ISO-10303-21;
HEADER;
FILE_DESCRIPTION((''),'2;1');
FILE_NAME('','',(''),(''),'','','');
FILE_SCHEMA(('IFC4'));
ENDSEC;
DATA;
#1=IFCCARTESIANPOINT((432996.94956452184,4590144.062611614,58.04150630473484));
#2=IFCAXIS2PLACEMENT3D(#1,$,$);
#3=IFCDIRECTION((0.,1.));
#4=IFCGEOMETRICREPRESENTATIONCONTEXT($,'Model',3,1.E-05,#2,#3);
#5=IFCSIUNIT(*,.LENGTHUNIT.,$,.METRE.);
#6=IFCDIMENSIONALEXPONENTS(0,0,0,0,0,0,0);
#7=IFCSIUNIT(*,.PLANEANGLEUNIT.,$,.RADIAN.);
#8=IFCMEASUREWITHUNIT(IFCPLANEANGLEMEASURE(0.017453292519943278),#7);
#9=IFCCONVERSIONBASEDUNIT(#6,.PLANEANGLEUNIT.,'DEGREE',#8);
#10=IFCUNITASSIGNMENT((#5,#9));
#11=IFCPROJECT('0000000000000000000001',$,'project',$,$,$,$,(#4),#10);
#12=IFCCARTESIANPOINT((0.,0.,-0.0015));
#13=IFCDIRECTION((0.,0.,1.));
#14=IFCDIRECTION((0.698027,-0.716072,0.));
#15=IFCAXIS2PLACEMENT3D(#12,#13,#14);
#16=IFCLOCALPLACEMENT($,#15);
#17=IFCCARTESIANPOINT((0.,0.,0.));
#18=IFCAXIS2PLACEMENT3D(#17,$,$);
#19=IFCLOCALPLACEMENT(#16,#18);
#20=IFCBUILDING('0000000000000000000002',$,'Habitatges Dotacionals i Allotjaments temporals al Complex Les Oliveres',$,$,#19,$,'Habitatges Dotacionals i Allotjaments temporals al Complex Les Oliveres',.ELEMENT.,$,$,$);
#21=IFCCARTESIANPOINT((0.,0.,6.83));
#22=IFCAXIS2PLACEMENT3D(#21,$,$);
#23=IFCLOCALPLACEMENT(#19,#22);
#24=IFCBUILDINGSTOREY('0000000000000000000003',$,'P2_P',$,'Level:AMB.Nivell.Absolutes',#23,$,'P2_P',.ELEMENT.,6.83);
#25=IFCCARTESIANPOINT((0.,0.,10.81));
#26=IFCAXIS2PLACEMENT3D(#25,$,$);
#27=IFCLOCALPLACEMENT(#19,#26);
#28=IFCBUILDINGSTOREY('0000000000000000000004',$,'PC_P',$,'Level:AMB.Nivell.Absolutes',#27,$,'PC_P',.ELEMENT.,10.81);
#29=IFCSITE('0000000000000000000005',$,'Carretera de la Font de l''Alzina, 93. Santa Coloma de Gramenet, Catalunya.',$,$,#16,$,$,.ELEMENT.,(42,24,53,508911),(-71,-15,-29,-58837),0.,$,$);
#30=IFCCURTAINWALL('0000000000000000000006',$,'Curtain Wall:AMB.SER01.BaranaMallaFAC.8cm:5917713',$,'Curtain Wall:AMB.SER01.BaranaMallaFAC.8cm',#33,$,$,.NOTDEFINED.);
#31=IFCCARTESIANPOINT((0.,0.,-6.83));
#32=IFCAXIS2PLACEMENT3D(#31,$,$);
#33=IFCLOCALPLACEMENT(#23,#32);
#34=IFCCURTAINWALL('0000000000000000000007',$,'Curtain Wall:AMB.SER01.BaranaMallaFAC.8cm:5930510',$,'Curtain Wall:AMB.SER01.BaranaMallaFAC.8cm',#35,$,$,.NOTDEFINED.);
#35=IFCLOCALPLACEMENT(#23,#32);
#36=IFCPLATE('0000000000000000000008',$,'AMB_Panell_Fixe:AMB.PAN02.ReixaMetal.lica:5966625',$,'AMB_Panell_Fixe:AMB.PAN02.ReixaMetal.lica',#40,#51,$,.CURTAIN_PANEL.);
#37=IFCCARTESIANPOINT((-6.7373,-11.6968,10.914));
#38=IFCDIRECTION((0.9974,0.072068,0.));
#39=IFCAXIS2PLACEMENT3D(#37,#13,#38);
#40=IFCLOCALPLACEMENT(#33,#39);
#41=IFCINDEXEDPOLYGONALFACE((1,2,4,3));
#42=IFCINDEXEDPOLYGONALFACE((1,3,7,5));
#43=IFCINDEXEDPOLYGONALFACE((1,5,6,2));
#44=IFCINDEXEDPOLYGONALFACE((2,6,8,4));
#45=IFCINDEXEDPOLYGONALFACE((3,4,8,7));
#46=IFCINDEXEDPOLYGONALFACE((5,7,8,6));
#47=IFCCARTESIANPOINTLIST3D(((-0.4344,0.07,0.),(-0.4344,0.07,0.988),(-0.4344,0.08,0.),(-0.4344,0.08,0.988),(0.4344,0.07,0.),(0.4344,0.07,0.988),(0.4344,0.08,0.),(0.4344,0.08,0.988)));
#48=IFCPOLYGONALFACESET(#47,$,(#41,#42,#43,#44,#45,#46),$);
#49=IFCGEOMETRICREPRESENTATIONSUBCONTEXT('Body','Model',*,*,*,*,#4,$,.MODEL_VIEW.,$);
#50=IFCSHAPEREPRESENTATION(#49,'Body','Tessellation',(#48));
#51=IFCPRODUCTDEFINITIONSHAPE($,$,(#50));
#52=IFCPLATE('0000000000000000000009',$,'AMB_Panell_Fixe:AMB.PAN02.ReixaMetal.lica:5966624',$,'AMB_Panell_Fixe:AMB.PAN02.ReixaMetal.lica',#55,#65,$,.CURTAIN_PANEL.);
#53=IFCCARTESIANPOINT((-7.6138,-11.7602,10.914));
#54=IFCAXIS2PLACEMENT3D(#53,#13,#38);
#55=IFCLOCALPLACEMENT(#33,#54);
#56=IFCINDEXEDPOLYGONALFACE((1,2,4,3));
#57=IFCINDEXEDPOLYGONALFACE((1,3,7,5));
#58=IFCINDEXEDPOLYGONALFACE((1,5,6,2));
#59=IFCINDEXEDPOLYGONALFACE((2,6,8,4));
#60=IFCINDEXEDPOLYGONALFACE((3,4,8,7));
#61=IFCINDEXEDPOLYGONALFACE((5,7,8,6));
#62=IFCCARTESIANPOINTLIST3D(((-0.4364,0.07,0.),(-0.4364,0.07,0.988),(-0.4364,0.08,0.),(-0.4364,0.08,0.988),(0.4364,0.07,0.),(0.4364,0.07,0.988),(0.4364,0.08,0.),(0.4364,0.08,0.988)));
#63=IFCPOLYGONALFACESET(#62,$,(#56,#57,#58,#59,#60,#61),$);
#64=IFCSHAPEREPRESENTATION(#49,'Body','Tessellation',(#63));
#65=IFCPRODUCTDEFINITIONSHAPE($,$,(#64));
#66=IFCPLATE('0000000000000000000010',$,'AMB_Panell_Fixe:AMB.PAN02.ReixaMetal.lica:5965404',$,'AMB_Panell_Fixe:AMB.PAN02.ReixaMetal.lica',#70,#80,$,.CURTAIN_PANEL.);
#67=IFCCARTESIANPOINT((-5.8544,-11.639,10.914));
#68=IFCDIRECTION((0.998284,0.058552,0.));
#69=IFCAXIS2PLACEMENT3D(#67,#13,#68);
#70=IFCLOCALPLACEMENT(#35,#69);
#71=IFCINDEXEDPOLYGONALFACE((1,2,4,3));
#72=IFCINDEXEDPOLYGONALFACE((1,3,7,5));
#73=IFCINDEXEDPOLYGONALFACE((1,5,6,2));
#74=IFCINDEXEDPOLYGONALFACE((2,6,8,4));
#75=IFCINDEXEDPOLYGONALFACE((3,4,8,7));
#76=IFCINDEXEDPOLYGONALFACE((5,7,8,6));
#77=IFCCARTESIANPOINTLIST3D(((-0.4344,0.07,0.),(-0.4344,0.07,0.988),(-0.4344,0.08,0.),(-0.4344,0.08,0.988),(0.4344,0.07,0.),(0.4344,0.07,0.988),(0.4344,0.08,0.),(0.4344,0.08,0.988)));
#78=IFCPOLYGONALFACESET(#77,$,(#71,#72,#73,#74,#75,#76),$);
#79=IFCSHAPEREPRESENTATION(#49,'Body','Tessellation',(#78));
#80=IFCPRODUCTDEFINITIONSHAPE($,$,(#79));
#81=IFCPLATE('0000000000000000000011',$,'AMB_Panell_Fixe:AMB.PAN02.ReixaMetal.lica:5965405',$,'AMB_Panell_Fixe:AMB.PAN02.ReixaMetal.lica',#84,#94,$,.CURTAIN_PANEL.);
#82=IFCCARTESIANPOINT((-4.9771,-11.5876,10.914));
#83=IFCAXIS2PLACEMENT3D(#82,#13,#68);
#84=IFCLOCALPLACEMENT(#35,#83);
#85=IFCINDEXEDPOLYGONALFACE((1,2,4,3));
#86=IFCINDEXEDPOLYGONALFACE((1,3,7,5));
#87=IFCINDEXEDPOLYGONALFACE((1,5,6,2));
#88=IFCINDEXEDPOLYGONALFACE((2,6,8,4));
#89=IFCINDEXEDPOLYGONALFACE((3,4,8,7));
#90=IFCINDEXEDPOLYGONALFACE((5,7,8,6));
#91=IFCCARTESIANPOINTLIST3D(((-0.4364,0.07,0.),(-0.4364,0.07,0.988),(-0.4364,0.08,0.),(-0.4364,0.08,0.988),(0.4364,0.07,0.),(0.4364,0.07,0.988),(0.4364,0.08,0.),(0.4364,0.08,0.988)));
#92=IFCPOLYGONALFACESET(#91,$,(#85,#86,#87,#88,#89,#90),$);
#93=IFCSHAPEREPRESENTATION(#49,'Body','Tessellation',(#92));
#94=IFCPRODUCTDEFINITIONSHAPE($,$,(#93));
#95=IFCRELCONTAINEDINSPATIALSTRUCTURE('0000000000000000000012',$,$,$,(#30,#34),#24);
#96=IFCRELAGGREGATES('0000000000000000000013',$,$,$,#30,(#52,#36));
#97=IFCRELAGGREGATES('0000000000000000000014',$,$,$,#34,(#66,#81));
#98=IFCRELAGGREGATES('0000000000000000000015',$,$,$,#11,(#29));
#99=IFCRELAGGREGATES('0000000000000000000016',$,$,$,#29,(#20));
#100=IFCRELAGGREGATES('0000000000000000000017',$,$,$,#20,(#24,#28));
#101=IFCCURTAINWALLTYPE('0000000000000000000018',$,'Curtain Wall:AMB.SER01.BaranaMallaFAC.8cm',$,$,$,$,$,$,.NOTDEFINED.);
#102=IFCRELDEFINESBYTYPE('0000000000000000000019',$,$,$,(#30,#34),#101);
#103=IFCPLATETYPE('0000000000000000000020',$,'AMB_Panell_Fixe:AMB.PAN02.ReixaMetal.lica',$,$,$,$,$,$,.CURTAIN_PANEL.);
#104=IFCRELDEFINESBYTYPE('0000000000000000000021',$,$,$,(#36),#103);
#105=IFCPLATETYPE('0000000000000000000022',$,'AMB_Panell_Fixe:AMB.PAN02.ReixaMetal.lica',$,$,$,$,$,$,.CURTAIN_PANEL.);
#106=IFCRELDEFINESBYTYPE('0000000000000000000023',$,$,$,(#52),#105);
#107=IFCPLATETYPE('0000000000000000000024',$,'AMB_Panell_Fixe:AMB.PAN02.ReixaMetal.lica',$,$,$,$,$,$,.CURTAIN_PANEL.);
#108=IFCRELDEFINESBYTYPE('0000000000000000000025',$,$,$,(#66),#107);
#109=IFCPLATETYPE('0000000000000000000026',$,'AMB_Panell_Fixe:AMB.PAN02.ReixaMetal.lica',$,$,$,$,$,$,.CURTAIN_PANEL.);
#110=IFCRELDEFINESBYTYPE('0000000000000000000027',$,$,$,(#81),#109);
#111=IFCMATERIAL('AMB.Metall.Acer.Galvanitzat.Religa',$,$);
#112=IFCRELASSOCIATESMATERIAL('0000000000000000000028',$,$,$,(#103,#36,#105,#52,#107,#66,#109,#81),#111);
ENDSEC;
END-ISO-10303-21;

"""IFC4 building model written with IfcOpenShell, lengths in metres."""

from ifc_helpers import new_model, entity, si_unit, converted_unit, direction, frame, origin, place, context, subcontext, project, spatial, indexed_curve, outline, extrude, source, transform, mapped, material, type_object, type_shapes, element, aggregate, save


model = new_model("IFC4")

# Units and contexts
model_context = context("Model", 3, precision=1e-05, world=frame((432996.94956452184, 4590144.062611614, 58.04150630473484)), true_north=direction((0.0, 1.0)))
body_context = subcontext(model_context, "Body", "Model", "MODEL_VIEW")
ifc_project = project(units=[si_unit("LENGTHUNIT", "METRE"), converted_unit("PLANEANGLEUNIT", "DEGREE", entity("IfcPlaneAngleMeasure", 0.017453292519943278), si_unit("PLANEANGLEUNIT", "RADIAN"), dimensions=[0, 0, 0, 0, 0, 0, 0])], contexts=[model_context])

# Site, building, storey
site_placement = place(None, frame((0.0, 0.0, -0.0015), z_axis=(0.0, 0.0, 1.0), x_axis=(0.698027, -0.716072, 0.0)))
site = spatial("IfcSite", under=ifc_project, at=site_placement, Name="Carretera de la Font de l'Alzina, 93. Santa Coloma de Gramenet, Catalunya.", CompositionType="ELEMENT", RefLatitude=(42, 24, 53, 508911), RefLongitude=(-71, -15, -29, -58837), RefElevation=0.0)
building_placement = place(site_placement, origin())
building = spatial("IfcBuilding", under=site, at=building_placement, Name="Habitatges Dotacionals i Allotjaments temporals al Complex Les Oliveres", LongName="Habitatges Dotacionals i Allotjaments temporals al Complex Les Oliveres", CompositionType="ELEMENT")
storey_1_placement = place(building_placement, frame((0.0, 0.0, 6.83)))
storey_1 = spatial("IfcBuildingStorey", under=building, at=storey_1_placement, Name="P2_P", ObjectType="Level:AMB.Nivell.Absolutes", LongName="P2_P", CompositionType="ELEMENT", Elevation=6.83)

# Curtain walls
curtain_wall_type = type_object("IfcCurtainWallType", Name="Curtain Wall:AMB.SER01.BaranaMallaFAC.8cm", PredefinedType="NOTDEFINED")
curtain_wall_1_placement = place(storey_1_placement, frame((0.0, 0.0, -6.83)))
curtain_wall_1 = element("IfcCurtainWall", 1, at=curtain_wall_1_placement, inside=storey_1, type_object=curtain_wall_type, Name="Curtain Wall:AMB.SER01.BaranaMallaFAC.8cm:5917713", ObjectType="Curtain Wall:AMB.SER01.BaranaMallaFAC.8cm", PredefinedType="NOTDEFINED")
curtain_wall_2_placement = place(storey_1_placement, frame((0.0, 0.0, -6.83)))
curtain_wall_2 = element("IfcCurtainWall", 2, at=curtain_wall_2_placement, inside=storey_1, type_object=curtain_wall_type, Name="Curtain Wall:AMB.SER01.BaranaMallaFAC.8cm:5930510", ObjectType="Curtain Wall:AMB.SER01.BaranaMallaFAC.8cm", PredefinedType="NOTDEFINED")

# Plates
ifc_material_1 = material(Name="AMB.Metall.Acer.Galvanitzat.Religa")
plate_type_1 = type_object("IfcPlateType", Name="AMB_Panell_Fixe:AMB.PAN02.ReixaMetal.lica", PredefinedType="CURTAIN_PANEL", material=ifc_material_1)
shared_shape_1 = source(origin(), body_context, "Body", "SweptSolid", [
    extrude(outline(indexed_curve([(-0.005, -0.4344), (0.005, -0.4344), (0.005, 0.4344), (-0.005, 0.4344), (-0.005, -0.4344)], self_intersect=False)), frame((0.0, 0.075, 0.0), z_axis=(0.0, 0.0, 1.0), x_axis=(0.0, 1.0, 0.0)), (0.0, 0.0, 1.0), 0.988),
])
type_shapes(plate_type_1, [shared_shape_1])
plate_1_placement = place(curtain_wall_1_placement, frame((-6.7373, -11.6968, 10.914), z_axis=(0.0, 0.0, 1.0), x_axis=(0.9974, 0.072068, 0.0)))
plate_1 = element("IfcPlate", 3, at=plate_1_placement, type_object=plate_type_1, material=ifc_material_1, Name="AMB_Panell_Fixe:AMB.PAN02.ReixaMetal.lica:5966625", ObjectType="AMB_Panell_Fixe:AMB.PAN02.ReixaMetal.lica", PredefinedType="CURTAIN_PANEL", context=body_context, shape_type="MappedRepresentation", body=[
    mapped(shared_shape_1, transform((0.0, 0.0, 0.0), scale=1.0)),
])
plate_type_2 = type_object("IfcPlateType", Name="AMB_Panell_Fixe:AMB.PAN02.ReixaMetal.lica", PredefinedType="CURTAIN_PANEL", material=ifc_material_1)
shared_shape_2 = source(origin(), body_context, "Body", "SweptSolid", [
    extrude(outline(indexed_curve([(-0.005, -0.4364), (0.005, -0.4364), (0.005, 0.4364), (-0.005, 0.4364), (-0.005, -0.4364)], self_intersect=False)), frame((0.0, 0.075, 0.0), z_axis=(0.0, 0.0, 1.0), x_axis=(0.0, 1.0, 0.0)), (0.0, 0.0, 1.0), 0.988),
])
type_shapes(plate_type_2, [shared_shape_2])
plate_2_placement = place(curtain_wall_1_placement, frame((-7.6138, -11.7602, 10.914), z_axis=(0.0, 0.0, 1.0), x_axis=(0.9974, 0.072068, 0.0)))
plate_2 = element("IfcPlate", 4, at=plate_2_placement, type_object=plate_type_2, material=ifc_material_1, Name="AMB_Panell_Fixe:AMB.PAN02.ReixaMetal.lica:5966624", ObjectType="AMB_Panell_Fixe:AMB.PAN02.ReixaMetal.lica", PredefinedType="CURTAIN_PANEL", context=body_context, shape_type="MappedRepresentation", body=[
    mapped(shared_shape_2, transform((0.0, 0.0, 0.0), scale=1.0)),
])
aggregate(curtain_wall_1, [plate_2, plate_1])
plate_type_3 = type_object("IfcPlateType", Name="AMB_Panell_Fixe:AMB.PAN02.ReixaMetal.lica", PredefinedType="CURTAIN_PANEL", material=ifc_material_1)
shared_shape_3 = source(origin(), body_context, "Body", "SweptSolid", [
    extrude(outline(indexed_curve([(-0.005, -0.4344), (0.005, -0.4344), (0.005, 0.4344), (-0.005, 0.4344), (-0.005, -0.4344)], self_intersect=False)), frame((0.0, 0.075, 0.0), z_axis=(0.0, 0.0, 1.0), x_axis=(0.0, 1.0, 0.0)), (0.0, 0.0, 1.0), 0.988),
])
type_shapes(plate_type_3, [shared_shape_3])
plate_3_placement = place(curtain_wall_2_placement, frame((-5.8544, -11.639, 10.914), z_axis=(0.0, 0.0, 1.0), x_axis=(0.998284, 0.058552, 0.0)))
plate_3 = element("IfcPlate", 5, at=plate_3_placement, type_object=plate_type_3, material=ifc_material_1, Name="AMB_Panell_Fixe:AMB.PAN02.ReixaMetal.lica:5965404", ObjectType="AMB_Panell_Fixe:AMB.PAN02.ReixaMetal.lica", PredefinedType="CURTAIN_PANEL", context=body_context, shape_type="MappedRepresentation", body=[
    mapped(shared_shape_3, transform((0.0, 0.0, 0.0), scale=1.0)),
])
plate_type_4 = type_object("IfcPlateType", Name="AMB_Panell_Fixe:AMB.PAN02.ReixaMetal.lica", PredefinedType="CURTAIN_PANEL", material=ifc_material_1)
shared_shape_4 = source(origin(), body_context, "Body", "SweptSolid", [
    extrude(outline(indexed_curve([(-0.005, -0.4364), (0.005, -0.4364), (0.005, 0.4364), (-0.005, 0.4364), (-0.005, -0.4364)], self_intersect=False)), frame((0.0, 0.075, 0.0), z_axis=(0.0, 0.0, 1.0), x_axis=(0.0, 1.0, 0.0)), (0.0, 0.0, 1.0), 0.988),
])
type_shapes(plate_type_4, [shared_shape_4])
plate_4_placement = place(curtain_wall_2_placement, frame((-4.9771, -11.5876, 10.914), z_axis=(0.0, 0.0, 1.0), x_axis=(0.998284, 0.058552, 0.0)))
plate_4 = element("IfcPlate", 6, at=plate_4_placement, type_object=plate_type_4, material=ifc_material_1, Name="AMB_Panell_Fixe:AMB.PAN02.ReixaMetal.lica:5965405", ObjectType="AMB_Panell_Fixe:AMB.PAN02.ReixaMetal.lica", PredefinedType="CURTAIN_PANEL", context=body_context, shape_type="MappedRepresentation", body=[
    mapped(shared_shape_4, transform((0.0, 0.0, 0.0), scale=1.0)),
])
aggregate(curtain_wall_2, [plate_3, plate_4])

# Shared definitions
storey_2_placement = place(building_placement, frame((0.0, 0.0, 10.81)))
storey_2 = spatial("IfcBuildingStorey", under=building, at=storey_2_placement, Name="PC_P", ObjectType="Level:AMB.Nivell.Absolutes", LongName="PC_P", CompositionType="ELEMENT", Elevation=10.81)

save(model, "model.ifc")
